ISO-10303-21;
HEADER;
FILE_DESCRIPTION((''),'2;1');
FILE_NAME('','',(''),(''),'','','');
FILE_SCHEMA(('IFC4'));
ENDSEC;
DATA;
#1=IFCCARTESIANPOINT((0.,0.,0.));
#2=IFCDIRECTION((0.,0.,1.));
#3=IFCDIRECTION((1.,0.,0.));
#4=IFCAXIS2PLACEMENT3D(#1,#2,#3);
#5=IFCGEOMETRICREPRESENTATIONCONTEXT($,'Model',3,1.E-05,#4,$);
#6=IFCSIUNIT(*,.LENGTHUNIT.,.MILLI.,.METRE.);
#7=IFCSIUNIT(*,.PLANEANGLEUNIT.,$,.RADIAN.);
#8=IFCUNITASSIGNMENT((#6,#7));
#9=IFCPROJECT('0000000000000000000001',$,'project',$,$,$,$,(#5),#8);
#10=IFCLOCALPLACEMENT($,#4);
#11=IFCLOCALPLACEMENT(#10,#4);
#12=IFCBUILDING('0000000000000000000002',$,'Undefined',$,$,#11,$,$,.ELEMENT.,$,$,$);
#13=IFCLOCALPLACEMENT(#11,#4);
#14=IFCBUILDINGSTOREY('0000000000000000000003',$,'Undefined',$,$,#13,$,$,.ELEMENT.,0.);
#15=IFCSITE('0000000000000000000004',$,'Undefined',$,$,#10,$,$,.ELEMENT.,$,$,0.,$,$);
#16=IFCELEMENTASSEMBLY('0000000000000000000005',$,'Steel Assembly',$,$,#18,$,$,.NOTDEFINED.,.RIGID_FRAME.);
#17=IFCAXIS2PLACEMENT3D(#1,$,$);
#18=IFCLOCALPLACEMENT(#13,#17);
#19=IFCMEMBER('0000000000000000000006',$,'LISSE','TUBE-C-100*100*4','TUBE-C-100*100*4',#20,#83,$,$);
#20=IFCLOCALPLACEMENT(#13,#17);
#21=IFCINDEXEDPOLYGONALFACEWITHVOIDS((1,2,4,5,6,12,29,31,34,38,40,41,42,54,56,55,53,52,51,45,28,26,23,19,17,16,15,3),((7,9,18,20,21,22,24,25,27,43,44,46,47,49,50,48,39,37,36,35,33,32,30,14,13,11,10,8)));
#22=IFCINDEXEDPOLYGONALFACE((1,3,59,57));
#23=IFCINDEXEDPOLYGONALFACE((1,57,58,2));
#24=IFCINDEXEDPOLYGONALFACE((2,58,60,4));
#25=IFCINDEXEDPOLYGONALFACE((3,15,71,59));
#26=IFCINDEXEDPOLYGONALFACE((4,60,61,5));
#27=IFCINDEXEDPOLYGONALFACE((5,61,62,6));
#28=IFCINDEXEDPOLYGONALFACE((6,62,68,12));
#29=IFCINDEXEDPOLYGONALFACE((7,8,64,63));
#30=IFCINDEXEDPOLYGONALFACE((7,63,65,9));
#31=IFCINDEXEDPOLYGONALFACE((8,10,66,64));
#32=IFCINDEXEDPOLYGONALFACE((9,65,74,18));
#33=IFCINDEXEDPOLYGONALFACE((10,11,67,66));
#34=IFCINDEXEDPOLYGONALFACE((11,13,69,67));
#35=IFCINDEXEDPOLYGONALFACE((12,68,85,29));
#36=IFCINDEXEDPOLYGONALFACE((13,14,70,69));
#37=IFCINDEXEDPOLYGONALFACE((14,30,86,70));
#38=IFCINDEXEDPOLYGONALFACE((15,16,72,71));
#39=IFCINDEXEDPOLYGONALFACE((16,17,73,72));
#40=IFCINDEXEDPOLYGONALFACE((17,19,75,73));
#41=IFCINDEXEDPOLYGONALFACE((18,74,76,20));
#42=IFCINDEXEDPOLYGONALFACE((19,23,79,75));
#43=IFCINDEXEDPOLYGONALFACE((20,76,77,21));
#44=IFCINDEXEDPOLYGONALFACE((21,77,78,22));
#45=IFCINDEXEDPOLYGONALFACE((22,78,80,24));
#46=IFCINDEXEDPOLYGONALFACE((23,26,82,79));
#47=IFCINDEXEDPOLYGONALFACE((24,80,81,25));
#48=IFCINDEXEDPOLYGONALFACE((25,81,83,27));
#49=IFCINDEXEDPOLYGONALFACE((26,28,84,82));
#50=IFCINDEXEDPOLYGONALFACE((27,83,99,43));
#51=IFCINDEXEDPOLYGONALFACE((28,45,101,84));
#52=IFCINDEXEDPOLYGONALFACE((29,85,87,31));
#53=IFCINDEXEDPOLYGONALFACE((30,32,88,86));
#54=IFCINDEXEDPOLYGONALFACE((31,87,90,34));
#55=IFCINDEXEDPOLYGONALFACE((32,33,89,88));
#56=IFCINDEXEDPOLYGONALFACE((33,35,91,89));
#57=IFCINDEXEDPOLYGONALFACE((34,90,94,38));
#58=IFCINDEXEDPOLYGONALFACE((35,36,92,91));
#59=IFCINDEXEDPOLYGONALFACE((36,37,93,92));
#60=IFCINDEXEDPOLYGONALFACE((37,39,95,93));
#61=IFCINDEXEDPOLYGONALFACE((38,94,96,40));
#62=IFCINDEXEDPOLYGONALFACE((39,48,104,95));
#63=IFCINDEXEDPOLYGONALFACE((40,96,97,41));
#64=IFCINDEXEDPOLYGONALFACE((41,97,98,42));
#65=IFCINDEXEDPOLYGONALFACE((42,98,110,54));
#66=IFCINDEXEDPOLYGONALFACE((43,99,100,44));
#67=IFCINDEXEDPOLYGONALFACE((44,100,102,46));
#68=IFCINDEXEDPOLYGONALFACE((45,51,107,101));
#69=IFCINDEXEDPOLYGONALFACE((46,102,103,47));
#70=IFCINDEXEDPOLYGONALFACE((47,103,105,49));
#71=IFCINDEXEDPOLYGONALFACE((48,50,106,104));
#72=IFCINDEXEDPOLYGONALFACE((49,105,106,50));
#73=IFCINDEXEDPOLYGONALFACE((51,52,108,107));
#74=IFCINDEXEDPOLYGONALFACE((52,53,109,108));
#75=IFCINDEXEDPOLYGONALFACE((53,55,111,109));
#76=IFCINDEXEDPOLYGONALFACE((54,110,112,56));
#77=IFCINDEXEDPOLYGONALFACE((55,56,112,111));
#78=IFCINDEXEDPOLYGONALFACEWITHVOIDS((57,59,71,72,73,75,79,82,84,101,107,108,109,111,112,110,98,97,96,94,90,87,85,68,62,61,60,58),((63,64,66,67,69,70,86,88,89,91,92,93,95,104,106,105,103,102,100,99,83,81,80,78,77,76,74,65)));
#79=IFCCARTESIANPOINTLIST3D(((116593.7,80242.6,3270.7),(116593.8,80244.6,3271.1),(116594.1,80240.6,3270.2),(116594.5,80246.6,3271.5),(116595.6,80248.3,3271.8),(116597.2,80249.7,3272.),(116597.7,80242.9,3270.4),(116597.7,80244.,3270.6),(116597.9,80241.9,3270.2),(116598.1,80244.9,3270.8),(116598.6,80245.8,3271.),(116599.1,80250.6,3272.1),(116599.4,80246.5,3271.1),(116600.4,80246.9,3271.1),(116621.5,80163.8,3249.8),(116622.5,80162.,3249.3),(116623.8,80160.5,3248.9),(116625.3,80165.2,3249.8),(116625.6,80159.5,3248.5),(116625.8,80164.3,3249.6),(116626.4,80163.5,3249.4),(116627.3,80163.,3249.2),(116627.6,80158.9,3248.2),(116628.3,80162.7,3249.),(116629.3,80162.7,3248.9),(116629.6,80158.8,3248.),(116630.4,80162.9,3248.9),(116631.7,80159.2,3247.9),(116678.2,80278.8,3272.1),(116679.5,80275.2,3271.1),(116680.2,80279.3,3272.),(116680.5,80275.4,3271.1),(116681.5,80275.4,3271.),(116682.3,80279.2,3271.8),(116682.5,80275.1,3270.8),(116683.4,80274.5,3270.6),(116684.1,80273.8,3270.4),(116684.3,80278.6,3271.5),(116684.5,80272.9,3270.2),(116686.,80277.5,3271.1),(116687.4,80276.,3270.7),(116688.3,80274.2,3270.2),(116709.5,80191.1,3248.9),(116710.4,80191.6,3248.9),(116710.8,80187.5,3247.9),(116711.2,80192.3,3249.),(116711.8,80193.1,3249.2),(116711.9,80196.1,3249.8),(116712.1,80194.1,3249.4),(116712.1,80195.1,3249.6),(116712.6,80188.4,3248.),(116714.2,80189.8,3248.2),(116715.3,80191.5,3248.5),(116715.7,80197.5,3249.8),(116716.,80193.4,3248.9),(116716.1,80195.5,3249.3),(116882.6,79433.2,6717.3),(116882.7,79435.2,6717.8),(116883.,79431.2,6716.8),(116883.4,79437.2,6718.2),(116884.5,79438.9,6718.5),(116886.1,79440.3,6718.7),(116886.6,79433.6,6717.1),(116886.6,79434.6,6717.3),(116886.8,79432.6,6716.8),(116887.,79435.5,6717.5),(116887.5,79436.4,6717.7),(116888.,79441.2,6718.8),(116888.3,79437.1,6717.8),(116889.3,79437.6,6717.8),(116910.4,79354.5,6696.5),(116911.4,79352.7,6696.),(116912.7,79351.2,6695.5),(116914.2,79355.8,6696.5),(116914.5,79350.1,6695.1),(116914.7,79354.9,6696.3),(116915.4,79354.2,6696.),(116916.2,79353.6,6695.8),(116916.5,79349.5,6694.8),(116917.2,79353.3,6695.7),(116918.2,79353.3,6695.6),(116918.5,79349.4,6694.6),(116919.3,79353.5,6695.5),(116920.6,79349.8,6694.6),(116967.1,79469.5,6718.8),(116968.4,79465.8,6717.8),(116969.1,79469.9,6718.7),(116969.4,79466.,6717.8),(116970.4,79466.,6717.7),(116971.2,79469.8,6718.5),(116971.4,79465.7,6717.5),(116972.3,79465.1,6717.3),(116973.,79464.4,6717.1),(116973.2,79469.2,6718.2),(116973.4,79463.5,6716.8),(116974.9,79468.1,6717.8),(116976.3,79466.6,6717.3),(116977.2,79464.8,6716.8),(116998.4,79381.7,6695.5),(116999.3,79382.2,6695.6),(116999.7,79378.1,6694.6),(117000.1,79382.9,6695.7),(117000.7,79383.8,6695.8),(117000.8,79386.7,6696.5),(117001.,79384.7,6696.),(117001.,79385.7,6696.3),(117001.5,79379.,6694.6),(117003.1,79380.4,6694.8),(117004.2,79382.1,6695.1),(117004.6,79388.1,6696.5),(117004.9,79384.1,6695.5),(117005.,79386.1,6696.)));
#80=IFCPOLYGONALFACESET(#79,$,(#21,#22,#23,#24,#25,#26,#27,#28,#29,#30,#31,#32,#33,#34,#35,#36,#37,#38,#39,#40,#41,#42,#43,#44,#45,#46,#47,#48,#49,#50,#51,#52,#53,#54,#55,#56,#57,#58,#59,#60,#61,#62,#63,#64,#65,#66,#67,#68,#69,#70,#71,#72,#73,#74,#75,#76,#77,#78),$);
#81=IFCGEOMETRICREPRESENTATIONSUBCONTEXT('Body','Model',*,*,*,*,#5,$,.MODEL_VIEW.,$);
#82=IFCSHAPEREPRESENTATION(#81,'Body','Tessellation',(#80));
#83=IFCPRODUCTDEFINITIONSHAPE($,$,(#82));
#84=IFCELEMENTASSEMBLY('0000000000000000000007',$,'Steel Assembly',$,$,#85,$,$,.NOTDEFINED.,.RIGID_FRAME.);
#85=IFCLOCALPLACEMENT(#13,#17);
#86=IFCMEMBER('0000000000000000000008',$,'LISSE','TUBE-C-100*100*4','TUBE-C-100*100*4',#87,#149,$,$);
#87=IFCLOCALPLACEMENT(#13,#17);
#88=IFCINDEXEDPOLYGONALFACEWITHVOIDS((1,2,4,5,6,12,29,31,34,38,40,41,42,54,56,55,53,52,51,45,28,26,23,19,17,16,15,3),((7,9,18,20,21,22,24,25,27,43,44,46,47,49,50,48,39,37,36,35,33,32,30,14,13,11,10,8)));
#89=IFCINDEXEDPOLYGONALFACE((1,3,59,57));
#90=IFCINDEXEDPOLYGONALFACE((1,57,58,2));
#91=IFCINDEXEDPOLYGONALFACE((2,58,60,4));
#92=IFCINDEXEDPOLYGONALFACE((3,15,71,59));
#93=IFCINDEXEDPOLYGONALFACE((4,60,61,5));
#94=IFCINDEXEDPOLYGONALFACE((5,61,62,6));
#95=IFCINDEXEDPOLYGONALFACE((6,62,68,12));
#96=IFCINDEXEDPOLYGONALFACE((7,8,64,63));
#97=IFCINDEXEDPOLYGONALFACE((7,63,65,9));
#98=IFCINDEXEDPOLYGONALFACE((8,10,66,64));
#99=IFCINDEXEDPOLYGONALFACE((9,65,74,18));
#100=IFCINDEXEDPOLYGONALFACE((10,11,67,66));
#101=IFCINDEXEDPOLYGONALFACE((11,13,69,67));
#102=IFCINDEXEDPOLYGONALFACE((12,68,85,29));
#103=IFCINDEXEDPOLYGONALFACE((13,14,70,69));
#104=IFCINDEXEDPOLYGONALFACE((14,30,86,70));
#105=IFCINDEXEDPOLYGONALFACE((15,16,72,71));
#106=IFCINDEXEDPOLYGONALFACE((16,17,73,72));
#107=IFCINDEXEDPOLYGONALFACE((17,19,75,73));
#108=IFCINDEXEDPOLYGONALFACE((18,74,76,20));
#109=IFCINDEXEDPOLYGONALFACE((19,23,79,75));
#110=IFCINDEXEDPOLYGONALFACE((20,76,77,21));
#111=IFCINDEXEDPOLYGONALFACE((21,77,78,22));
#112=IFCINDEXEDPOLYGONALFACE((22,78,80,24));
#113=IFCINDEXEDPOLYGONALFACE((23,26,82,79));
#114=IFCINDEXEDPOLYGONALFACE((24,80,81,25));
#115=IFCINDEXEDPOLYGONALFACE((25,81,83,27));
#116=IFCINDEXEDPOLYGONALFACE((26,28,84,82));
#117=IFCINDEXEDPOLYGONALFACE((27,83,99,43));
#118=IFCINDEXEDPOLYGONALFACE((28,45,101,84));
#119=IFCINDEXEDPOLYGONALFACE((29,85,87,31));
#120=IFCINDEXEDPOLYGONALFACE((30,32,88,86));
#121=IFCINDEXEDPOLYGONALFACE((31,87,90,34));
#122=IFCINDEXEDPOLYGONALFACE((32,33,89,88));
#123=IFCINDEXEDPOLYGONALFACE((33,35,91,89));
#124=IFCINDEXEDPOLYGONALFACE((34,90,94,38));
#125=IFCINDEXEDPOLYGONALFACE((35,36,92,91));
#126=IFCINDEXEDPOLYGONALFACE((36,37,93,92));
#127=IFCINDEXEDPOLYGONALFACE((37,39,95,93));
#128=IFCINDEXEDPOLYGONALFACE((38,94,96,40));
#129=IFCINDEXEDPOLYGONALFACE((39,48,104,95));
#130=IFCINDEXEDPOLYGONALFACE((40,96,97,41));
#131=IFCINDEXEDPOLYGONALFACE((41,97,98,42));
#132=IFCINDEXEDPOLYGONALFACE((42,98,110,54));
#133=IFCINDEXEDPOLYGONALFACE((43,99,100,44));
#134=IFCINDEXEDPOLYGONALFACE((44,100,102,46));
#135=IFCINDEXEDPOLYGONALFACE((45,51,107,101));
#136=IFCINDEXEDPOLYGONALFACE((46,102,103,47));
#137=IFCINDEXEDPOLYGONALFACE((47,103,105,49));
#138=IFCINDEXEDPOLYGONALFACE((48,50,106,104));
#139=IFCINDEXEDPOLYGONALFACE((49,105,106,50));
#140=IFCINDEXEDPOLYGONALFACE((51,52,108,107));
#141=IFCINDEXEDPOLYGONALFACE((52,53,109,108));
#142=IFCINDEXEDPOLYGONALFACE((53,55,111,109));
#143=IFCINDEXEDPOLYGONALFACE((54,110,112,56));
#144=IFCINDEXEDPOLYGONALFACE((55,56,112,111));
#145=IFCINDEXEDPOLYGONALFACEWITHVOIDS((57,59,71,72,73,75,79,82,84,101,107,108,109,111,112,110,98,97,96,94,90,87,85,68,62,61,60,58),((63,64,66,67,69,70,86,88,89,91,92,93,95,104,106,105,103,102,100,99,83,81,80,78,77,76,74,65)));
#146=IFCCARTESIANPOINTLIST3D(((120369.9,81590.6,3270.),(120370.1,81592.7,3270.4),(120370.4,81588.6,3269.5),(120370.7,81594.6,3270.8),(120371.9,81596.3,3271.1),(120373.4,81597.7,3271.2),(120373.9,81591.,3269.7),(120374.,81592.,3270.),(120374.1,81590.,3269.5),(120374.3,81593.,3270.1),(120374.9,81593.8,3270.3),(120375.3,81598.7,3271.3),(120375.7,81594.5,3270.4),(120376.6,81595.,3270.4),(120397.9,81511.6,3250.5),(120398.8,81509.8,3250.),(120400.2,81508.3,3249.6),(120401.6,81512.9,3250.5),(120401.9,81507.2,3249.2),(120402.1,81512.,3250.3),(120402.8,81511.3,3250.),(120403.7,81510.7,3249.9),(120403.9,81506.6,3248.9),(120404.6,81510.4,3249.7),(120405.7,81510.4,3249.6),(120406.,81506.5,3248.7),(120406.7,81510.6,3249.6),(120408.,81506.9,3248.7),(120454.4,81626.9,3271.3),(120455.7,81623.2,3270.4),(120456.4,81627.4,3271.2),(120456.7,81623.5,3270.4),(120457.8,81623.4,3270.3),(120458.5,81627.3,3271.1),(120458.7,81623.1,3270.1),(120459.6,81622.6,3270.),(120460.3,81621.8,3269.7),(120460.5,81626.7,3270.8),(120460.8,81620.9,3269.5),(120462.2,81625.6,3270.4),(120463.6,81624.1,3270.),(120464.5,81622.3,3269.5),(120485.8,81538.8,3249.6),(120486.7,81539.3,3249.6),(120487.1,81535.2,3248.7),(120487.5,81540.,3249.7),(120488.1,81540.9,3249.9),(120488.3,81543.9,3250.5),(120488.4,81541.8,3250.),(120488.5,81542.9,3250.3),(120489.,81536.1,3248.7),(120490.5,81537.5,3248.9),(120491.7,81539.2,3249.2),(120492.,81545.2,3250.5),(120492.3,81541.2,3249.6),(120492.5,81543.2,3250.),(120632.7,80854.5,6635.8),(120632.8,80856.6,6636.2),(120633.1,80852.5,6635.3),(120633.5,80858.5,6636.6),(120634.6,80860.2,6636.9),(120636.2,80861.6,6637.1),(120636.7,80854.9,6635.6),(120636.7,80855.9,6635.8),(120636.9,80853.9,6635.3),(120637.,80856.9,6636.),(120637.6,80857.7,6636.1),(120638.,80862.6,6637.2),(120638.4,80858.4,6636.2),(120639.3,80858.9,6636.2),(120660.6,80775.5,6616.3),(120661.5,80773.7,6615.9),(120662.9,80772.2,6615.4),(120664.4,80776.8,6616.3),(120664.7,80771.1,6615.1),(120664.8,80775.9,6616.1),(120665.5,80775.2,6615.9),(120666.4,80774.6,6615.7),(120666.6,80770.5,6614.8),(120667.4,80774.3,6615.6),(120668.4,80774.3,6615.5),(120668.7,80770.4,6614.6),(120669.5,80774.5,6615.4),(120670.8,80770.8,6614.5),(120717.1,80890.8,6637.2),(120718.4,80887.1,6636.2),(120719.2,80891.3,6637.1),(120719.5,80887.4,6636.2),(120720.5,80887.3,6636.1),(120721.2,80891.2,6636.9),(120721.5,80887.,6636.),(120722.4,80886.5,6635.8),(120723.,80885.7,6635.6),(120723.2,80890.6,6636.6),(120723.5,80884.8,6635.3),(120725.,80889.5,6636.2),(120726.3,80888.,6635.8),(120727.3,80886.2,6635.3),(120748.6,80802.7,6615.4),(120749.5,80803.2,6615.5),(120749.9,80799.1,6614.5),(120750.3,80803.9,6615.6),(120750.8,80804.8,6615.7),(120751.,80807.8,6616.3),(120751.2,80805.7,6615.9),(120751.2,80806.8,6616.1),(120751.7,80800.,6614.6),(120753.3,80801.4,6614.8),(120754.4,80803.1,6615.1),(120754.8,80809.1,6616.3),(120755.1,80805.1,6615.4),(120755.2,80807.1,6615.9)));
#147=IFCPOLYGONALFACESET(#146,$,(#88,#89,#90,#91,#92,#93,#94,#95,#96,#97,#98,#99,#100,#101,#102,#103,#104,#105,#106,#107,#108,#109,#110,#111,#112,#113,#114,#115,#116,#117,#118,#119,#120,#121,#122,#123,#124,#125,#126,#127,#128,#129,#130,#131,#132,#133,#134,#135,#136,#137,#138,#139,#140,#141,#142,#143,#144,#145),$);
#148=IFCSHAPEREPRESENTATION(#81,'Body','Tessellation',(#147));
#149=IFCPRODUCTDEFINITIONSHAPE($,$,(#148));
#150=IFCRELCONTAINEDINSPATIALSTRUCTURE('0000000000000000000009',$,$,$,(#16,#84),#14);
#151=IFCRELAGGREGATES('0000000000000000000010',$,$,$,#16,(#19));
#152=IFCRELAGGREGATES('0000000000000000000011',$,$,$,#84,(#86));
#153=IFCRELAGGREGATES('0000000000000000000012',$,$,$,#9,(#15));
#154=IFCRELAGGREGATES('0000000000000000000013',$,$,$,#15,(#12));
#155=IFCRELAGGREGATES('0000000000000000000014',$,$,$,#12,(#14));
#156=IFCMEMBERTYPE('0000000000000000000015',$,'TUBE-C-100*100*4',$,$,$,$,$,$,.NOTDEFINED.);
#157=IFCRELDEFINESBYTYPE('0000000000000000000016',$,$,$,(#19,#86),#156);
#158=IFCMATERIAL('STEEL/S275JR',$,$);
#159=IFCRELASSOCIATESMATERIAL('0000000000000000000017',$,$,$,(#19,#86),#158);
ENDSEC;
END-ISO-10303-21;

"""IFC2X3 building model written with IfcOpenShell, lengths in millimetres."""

from ifc_helpers import new_model, si_unit, frame, origin_with_axes, origin_2d_with_axis, place, context, subcontext, project, spatial, hollow_rectangle, extrude, material, type_object, element, aggregate, save


model = new_model("IFC2X3")

# Units and contexts
model_context = context("Model", 3, precision=1e-05, world=origin_with_axes())
body_context = subcontext(model_context, "Body", "Model", "MODEL_VIEW")
ifc_project = project(units=[si_unit("LENGTHUNIT", "METRE", prefix="MILLI"), si_unit("PLANEANGLEUNIT", "RADIAN")], contexts=[model_context])

# Site, building, storey
site_placement = place(None, origin_with_axes())
site = spatial("IfcSite", under=ifc_project, at=site_placement, Name="Undefined", CompositionType="ELEMENT", RefElevation=0.0)
building_placement = place(site_placement, origin_with_axes())
building = spatial("IfcBuilding", under=site, at=building_placement, Name="Undefined", CompositionType="ELEMENT")
storey_placement = place(building_placement, origin_with_axes())
storey = spatial("IfcBuildingStorey", under=building, at=storey_placement, Name="Undefined", CompositionType="ELEMENT", Elevation=0.0)

# Shared definitions
ifc_material = material(Name="STEEL/S275JR")

# Element assemblies, members
assembly_1_placement = place(storey_placement, origin_with_axes())
assembly_1 = element("IfcElementAssembly", 1, at=assembly_1_placement, inside=storey, Name="Steel Assembly", AssemblyPlace="NOTDEFINED", PredefinedType="RIGID_FRAME")
member_type = type_object("IfcMemberType", Name="TUBE-C-100*100*4", PredefinedType="NOTDEFINED")
member_1_placement = place(assembly_1_placement, frame((116943.8, 79409.6, 6706.7), z_axis=(0.941802, 0.336168, 0.0), x_axis=(-0.081331, 0.227854, -0.970293)))
member_1 = element("IfcMember", 2, at=member_1_placement, type_object=member_type, material=ifc_material, Name="LISSE", Description="TUBE-C-100*100*4", ObjectType="TUBE-C-100*100*4", context=body_context, shape_type="SweptSolid", body=[
    extrude(hollow_rectangle(XDim=100.0, YDim=100.0, WallThickness=4.0, InnerFilletRadius=4.0, OuterFilletRadius=8.0, at=origin_2d_with_axis()), frame((3552.2, 0.0, 0.0), z_axis=(-1.0, 0.0, 0.0), x_axis=(0.0, -1.0, 0.0)), (0.0, 0.0, 1.0), 3552.2),
])
aggregate(assembly_1, [member_1])
assembly_2_placement = place(storey_placement, origin_with_axes())
assembly_2 = element("IfcElementAssembly", 3, at=assembly_2_placement, inside=storey, Name="Steel Assembly", AssemblyPlace="NOTDEFINED", PredefinedType="RIGID_FRAME")
member_2_placement = place(assembly_2_placement, frame((120693.9, 80830.8, 6625.8), z_axis=(0.941802, 0.336168, 0.0), x_axis=(-0.076039, 0.213029, -0.974083)))
member_2 = element("IfcMember", 4, at=member_2_placement, type_object=member_type, material=ifc_material, Name="LISSE", Description="TUBE-C-100*100*4", ObjectType="TUBE-C-100*100*4", context=body_context, shape_type="SweptSolid", body=[
    extrude(hollow_rectangle(XDim=100.0, YDim=100.0, WallThickness=4.0, InnerFilletRadius=4.0, OuterFilletRadius=8.0, at=origin_2d_with_axis()), frame((3455.4, 0.0, 0.0), z_axis=(-1.0, 0.0, 0.0), x_axis=(0.0, -1.0, 0.0)), (0.0, 0.0, 1.0), 3455.4),
])
aggregate(assembly_2, [member_2])

save(model, "model.ifc")
